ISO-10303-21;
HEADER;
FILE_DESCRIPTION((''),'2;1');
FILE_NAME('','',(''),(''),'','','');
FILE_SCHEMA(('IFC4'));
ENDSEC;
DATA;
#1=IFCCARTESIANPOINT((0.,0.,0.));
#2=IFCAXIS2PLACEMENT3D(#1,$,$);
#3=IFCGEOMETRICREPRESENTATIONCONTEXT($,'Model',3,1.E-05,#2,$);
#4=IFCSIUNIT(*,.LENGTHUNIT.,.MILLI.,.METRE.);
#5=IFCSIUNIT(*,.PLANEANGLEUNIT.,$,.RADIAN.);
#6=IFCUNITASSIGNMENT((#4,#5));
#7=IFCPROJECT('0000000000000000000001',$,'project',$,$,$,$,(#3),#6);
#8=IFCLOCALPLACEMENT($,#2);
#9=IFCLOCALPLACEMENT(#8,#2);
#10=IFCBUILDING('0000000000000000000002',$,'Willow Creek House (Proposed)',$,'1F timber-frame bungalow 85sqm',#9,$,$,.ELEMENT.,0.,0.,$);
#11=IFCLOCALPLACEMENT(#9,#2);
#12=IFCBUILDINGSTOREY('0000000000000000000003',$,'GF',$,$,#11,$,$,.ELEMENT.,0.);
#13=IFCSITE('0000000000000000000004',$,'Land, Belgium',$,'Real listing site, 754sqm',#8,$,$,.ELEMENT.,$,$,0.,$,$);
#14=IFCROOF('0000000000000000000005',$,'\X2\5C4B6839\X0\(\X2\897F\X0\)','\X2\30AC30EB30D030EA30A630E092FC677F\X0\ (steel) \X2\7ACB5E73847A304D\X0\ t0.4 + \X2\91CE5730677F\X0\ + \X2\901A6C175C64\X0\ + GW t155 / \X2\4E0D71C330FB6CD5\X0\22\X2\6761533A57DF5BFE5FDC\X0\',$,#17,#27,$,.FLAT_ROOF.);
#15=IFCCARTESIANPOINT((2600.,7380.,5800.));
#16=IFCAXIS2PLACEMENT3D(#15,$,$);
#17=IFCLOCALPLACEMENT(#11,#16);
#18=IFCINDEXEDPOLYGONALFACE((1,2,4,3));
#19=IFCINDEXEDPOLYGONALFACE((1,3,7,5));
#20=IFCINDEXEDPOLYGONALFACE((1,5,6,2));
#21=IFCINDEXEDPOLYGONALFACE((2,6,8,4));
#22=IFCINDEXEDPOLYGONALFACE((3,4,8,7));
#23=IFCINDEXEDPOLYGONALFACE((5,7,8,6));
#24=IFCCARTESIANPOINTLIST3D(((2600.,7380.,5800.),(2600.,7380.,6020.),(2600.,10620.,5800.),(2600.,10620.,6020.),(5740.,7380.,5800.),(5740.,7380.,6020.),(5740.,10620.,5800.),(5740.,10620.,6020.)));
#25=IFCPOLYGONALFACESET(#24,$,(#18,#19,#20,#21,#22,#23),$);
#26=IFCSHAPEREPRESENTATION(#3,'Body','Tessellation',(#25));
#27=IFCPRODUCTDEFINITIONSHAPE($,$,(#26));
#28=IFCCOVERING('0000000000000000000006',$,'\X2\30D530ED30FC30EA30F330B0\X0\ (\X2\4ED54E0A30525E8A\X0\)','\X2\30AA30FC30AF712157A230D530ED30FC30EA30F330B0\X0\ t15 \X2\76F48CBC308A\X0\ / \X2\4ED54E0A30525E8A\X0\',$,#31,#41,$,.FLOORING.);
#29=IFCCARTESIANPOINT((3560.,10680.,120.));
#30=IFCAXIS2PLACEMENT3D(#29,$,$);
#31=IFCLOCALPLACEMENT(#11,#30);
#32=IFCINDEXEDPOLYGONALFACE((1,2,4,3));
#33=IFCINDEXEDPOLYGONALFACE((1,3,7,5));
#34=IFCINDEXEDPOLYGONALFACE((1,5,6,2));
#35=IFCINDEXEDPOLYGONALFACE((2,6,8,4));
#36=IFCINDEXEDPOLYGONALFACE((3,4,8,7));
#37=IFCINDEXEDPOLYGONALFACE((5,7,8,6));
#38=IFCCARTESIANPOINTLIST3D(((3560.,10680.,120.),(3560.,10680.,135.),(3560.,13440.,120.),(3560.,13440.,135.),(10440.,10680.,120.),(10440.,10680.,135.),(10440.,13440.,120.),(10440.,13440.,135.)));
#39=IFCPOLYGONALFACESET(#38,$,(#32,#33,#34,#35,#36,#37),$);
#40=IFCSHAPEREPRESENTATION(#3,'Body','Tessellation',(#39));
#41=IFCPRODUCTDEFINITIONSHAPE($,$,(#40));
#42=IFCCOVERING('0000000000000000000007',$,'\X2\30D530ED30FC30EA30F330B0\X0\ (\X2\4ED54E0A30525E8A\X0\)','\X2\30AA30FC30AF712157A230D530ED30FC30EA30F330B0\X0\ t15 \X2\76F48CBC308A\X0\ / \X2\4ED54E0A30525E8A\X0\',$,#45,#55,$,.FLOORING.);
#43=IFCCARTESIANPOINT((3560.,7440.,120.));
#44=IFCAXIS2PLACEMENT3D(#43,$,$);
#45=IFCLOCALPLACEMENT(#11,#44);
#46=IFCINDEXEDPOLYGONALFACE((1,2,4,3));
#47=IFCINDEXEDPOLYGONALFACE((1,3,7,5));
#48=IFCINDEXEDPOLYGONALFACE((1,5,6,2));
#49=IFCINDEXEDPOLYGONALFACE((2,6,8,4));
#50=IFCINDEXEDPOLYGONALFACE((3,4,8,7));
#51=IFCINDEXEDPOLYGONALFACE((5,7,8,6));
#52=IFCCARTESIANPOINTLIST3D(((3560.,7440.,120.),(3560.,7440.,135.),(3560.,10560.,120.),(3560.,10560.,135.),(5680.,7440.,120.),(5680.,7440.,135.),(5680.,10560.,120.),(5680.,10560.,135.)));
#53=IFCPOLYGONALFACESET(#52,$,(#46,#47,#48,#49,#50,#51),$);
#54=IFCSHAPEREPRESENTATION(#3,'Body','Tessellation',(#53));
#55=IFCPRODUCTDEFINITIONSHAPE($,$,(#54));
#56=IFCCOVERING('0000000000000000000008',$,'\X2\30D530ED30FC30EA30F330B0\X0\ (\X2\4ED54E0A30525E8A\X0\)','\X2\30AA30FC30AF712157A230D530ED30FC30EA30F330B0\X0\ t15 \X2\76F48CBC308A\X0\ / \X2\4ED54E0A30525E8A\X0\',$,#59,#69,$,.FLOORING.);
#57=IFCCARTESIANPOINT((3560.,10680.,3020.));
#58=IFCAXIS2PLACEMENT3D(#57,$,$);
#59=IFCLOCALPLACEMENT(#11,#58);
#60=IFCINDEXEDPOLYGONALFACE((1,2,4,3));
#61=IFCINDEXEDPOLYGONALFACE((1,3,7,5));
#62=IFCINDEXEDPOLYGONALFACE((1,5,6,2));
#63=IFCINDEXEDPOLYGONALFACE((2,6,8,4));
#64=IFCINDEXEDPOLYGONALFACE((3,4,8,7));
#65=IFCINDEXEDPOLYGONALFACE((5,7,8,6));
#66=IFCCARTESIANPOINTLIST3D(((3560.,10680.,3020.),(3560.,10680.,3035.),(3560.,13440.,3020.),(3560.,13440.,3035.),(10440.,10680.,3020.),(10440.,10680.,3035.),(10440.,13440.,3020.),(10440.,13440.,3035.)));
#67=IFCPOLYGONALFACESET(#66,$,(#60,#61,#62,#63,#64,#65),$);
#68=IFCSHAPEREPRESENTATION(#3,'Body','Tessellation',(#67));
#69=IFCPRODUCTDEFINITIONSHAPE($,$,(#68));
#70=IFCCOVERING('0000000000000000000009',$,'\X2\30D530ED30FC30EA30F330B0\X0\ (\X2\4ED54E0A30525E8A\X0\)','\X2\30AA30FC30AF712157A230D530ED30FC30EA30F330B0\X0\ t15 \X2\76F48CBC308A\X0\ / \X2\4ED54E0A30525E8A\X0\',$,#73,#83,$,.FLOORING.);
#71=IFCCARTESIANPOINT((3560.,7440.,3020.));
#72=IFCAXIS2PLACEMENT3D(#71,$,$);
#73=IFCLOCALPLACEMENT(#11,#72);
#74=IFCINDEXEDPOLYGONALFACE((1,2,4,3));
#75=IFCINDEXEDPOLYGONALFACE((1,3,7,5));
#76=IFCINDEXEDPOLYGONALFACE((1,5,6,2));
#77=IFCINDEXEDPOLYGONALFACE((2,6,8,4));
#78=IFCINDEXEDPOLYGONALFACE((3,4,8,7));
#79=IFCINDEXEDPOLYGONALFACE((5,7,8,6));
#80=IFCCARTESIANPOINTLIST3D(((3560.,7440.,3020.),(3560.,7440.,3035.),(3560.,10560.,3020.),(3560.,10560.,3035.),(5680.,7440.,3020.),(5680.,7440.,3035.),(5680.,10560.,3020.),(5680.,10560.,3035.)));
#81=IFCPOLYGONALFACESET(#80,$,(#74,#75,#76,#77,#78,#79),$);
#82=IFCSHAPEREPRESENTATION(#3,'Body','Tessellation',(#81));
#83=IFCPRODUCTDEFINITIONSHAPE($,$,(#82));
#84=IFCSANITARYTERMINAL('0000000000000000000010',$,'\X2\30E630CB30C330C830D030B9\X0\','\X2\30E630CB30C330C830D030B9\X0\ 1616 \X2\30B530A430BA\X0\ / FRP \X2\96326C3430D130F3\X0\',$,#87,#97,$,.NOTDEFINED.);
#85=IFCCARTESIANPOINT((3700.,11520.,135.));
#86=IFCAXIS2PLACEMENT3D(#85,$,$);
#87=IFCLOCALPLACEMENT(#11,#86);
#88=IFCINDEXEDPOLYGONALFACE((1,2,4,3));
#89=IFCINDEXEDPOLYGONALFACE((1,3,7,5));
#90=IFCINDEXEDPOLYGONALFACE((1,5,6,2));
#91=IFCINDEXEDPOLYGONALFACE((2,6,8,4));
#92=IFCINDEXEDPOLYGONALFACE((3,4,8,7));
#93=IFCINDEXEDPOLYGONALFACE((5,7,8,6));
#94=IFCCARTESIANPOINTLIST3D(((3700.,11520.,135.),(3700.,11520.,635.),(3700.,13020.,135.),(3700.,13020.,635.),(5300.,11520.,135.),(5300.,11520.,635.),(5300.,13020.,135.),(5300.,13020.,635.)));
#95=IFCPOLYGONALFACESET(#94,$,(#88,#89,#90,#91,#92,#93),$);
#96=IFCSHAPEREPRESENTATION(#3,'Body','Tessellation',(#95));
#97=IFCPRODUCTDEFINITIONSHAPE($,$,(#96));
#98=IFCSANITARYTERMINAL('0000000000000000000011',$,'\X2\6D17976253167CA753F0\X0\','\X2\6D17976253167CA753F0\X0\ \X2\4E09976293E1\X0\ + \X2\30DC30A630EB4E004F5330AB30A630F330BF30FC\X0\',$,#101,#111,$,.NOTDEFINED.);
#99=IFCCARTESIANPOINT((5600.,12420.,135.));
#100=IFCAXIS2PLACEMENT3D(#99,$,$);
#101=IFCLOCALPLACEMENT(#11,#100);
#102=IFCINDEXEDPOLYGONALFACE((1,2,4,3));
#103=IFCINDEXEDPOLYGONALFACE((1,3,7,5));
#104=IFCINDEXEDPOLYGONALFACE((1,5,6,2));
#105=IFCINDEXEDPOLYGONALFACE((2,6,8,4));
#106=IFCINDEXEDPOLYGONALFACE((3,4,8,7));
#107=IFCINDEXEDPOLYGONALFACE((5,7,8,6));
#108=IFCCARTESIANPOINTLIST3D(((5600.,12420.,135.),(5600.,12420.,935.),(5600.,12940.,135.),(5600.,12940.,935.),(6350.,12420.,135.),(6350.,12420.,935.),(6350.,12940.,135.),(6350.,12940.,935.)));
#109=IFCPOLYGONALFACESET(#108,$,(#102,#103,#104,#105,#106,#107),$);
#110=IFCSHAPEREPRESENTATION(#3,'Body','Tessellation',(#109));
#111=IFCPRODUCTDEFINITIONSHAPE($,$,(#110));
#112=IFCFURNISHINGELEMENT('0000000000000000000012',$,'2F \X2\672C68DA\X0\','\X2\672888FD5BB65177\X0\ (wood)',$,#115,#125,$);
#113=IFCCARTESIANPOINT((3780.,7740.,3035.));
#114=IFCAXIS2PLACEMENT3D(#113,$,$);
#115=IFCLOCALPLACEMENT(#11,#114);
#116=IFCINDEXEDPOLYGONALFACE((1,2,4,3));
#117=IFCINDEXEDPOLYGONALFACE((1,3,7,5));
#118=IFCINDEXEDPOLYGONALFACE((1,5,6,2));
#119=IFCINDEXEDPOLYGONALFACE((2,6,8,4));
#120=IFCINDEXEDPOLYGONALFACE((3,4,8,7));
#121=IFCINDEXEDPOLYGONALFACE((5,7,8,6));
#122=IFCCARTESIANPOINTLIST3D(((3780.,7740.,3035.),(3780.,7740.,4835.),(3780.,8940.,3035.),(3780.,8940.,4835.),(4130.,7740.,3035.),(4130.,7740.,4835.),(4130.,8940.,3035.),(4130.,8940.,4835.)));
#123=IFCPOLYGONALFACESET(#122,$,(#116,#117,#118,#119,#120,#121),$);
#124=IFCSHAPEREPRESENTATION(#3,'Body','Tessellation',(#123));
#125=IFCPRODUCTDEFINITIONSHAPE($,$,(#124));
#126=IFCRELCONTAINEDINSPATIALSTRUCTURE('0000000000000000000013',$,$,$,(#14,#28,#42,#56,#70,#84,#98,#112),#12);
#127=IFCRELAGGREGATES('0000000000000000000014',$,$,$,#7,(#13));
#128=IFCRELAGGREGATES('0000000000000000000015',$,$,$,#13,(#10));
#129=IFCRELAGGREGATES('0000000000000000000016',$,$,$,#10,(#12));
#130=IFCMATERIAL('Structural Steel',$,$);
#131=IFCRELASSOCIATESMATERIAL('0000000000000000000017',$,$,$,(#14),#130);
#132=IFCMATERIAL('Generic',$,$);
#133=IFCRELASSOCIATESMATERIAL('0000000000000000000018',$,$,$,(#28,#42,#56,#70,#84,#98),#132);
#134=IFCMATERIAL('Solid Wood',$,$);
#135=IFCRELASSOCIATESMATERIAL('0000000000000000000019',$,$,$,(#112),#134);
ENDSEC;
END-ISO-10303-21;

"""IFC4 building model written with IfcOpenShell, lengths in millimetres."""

from ifc_helpers import new_model, si_unit, frame, frame_2d, origin, place, context, project, spatial, rectangle, extrude, material, element, save


model = new_model("IFC4")

# Units and contexts
model_context = context("Model", 3, precision=1e-05, world=origin())
ifc_project = project(units=[si_unit("LENGTHUNIT", "METRE", prefix="MILLI"), si_unit("PLANEANGLEUNIT", "RADIAN")], contexts=[model_context])

# Site, building, storey
site_placement = place(None, origin())
site = spatial("IfcSite", under=ifc_project, at=site_placement, Name="Land, Belgium", ObjectType="Real listing site, 754sqm", CompositionType="ELEMENT", RefElevation=0.0)
building_placement = place(site_placement, origin())
building = spatial("IfcBuilding", under=site, at=building_placement, Name="Willow Creek House (Proposed)", ObjectType="1F timber-frame bungalow 85sqm", CompositionType="ELEMENT", ElevationOfRefHeight=0.0, ElevationOfTerrain=0.0)
storey_placement = place(building_placement, origin())
storey = spatial("IfcBuildingStorey", under=building, at=storey_placement, Name="GF", CompositionType="ELEMENT", Elevation=0.0)

# Shared definitions
ifc_material_1 = material(Name="Solid Wood")

# Roof
ifc_material_2 = material(Name="Structural Steel")
roof_placement = place(storey_placement, frame((2600.0, 7380.0, 5800.0)))
element("IfcRoof", 1, at=roof_placement, inside=storey, material=ifc_material_2, Name="屋根(西)", Description="ガルバリウム鋼板 (steel) 立平葺き t0.4 + 野地板 + 通気層 + GW t155 / 不燃・法22条区域対応", PredefinedType="FLAT_ROOF", context=model_context, shape_type="SweptSolid", body=[
    extrude(rectangle(XDim=3140.0, YDim=3240.0, at=frame_2d((1570.0, 1620.0))), frame((2600.0, 7380.0, 5800.0)), (0.0, 0.0, 1.0), 220.0),
])

# Coverings
ifc_material_3 = material(Name="Generic")
covering_1_placement = place(storey_placement, frame((3560.0, 10680.0, 120.0)))
element("IfcCovering", 2, at=covering_1_placement, inside=storey, material=ifc_material_3, Name="フローリング (仕上げ床)", Description="オーク無垢フローリング t15 直貼り / 仕上げ床", PredefinedType="FLOORING", context=model_context, shape_type="SweptSolid", body=[
    extrude(rectangle(XDim=6880.0, YDim=2760.0, at=frame_2d((3440.0, 1380.0))), frame((3560.0, 10680.0, 120.0)), (0.0, 0.0, 1.0), 15.0),
])
covering_2_placement = place(storey_placement, frame((3560.0, 7440.0, 120.0)))
element("IfcCovering", 3, at=covering_2_placement, inside=storey, material=ifc_material_3, Name="フローリング (仕上げ床)", Description="オーク無垢フローリング t15 直貼り / 仕上げ床", PredefinedType="FLOORING", context=model_context, shape_type="SweptSolid", body=[
    extrude(rectangle(XDim=2120.0, YDim=3120.0, at=frame_2d((1060.0, 1560.0))), frame((3560.0, 7440.0, 120.0)), (0.0, 0.0, 1.0), 15.0),
])
covering_3_placement = place(storey_placement, frame((3560.0, 10680.0, 3020.0)))
element("IfcCovering", 4, at=covering_3_placement, inside=storey, material=ifc_material_3, Name="フローリング (仕上げ床)", Description="オーク無垢フローリング t15 直貼り / 仕上げ床", PredefinedType="FLOORING", context=model_context, shape_type="SweptSolid", body=[
    extrude(rectangle(XDim=6880.0, YDim=2760.0, at=frame_2d((3440.0, 1380.0))), frame((3560.0, 10680.0, 3020.0)), (0.0, 0.0, 1.0), 15.0),
])
covering_4_placement = place(storey_placement, frame((3560.0, 7440.0, 3020.0)))
element("IfcCovering", 5, at=covering_4_placement, inside=storey, material=ifc_material_3, Name="フローリング (仕上げ床)", Description="オーク無垢フローリング t15 直貼り / 仕上げ床", PredefinedType="FLOORING", context=model_context, shape_type="SweptSolid", body=[
    extrude(rectangle(XDim=2120.0, YDim=3120.0, at=frame_2d((1060.0, 1560.0))), frame((3560.0, 7440.0, 3020.0)), (0.0, 0.0, 1.0), 15.0),
])

# Sanitary terminals
sanitary_terminal_1_placement = place(storey_placement, frame((3700.0, 11520.0, 135.0)))
element("IfcSanitaryTerminal", 6, at=sanitary_terminal_1_placement, inside=storey, material=ifc_material_3, Name="ユニットバス", Description="ユニットバス 1616 サイズ / FRP 防水パン", PredefinedType="NOTDEFINED", context=model_context, shape_type="SweptSolid", body=[
    extrude(rectangle(XDim=1600.0, YDim=1500.0, at=frame_2d((800.0, 750.0))), frame((3700.0, 11520.0, 135.0)), (0.0, 0.0, 1.0), 500.0),
])
sanitary_terminal_2_placement = place(storey_placement, frame((5600.0, 12420.0, 135.0)))
element("IfcSanitaryTerminal", 7, at=sanitary_terminal_2_placement, inside=storey, material=ifc_material_3, Name="洗面化粧台", Description="洗面化粧台 三面鏡 + ボウル一体カウンター", PredefinedType="NOTDEFINED", context=model_context, shape_type="SweptSolid", body=[
    extrude(rectangle(XDim=750.0, YDim=520.0, at=frame_2d((375.0, 260.0))), frame((5600.0, 12420.0, 135.0)), (0.0, 0.0, 1.0), 800.0),
])

# Furnishing element
furnishing_placement = place(storey_placement, frame((3780.0, 7740.0, 3035.0)))
element("IfcFurnishingElement", 8, at=furnishing_placement, inside=storey, material=ifc_material_1, Name="2F 本棚", Description="木製家具 (wood)", context=model_context, shape_type="SweptSolid", body=[
    extrude(rectangle(XDim=350.0, YDim=1200.0, at=frame_2d((175.0, 600.0))), frame((3780.0, 7740.0, 3035.0)), (0.0, 0.0, 1.0), 1800.0),
])

save(model, "model.ifc")
